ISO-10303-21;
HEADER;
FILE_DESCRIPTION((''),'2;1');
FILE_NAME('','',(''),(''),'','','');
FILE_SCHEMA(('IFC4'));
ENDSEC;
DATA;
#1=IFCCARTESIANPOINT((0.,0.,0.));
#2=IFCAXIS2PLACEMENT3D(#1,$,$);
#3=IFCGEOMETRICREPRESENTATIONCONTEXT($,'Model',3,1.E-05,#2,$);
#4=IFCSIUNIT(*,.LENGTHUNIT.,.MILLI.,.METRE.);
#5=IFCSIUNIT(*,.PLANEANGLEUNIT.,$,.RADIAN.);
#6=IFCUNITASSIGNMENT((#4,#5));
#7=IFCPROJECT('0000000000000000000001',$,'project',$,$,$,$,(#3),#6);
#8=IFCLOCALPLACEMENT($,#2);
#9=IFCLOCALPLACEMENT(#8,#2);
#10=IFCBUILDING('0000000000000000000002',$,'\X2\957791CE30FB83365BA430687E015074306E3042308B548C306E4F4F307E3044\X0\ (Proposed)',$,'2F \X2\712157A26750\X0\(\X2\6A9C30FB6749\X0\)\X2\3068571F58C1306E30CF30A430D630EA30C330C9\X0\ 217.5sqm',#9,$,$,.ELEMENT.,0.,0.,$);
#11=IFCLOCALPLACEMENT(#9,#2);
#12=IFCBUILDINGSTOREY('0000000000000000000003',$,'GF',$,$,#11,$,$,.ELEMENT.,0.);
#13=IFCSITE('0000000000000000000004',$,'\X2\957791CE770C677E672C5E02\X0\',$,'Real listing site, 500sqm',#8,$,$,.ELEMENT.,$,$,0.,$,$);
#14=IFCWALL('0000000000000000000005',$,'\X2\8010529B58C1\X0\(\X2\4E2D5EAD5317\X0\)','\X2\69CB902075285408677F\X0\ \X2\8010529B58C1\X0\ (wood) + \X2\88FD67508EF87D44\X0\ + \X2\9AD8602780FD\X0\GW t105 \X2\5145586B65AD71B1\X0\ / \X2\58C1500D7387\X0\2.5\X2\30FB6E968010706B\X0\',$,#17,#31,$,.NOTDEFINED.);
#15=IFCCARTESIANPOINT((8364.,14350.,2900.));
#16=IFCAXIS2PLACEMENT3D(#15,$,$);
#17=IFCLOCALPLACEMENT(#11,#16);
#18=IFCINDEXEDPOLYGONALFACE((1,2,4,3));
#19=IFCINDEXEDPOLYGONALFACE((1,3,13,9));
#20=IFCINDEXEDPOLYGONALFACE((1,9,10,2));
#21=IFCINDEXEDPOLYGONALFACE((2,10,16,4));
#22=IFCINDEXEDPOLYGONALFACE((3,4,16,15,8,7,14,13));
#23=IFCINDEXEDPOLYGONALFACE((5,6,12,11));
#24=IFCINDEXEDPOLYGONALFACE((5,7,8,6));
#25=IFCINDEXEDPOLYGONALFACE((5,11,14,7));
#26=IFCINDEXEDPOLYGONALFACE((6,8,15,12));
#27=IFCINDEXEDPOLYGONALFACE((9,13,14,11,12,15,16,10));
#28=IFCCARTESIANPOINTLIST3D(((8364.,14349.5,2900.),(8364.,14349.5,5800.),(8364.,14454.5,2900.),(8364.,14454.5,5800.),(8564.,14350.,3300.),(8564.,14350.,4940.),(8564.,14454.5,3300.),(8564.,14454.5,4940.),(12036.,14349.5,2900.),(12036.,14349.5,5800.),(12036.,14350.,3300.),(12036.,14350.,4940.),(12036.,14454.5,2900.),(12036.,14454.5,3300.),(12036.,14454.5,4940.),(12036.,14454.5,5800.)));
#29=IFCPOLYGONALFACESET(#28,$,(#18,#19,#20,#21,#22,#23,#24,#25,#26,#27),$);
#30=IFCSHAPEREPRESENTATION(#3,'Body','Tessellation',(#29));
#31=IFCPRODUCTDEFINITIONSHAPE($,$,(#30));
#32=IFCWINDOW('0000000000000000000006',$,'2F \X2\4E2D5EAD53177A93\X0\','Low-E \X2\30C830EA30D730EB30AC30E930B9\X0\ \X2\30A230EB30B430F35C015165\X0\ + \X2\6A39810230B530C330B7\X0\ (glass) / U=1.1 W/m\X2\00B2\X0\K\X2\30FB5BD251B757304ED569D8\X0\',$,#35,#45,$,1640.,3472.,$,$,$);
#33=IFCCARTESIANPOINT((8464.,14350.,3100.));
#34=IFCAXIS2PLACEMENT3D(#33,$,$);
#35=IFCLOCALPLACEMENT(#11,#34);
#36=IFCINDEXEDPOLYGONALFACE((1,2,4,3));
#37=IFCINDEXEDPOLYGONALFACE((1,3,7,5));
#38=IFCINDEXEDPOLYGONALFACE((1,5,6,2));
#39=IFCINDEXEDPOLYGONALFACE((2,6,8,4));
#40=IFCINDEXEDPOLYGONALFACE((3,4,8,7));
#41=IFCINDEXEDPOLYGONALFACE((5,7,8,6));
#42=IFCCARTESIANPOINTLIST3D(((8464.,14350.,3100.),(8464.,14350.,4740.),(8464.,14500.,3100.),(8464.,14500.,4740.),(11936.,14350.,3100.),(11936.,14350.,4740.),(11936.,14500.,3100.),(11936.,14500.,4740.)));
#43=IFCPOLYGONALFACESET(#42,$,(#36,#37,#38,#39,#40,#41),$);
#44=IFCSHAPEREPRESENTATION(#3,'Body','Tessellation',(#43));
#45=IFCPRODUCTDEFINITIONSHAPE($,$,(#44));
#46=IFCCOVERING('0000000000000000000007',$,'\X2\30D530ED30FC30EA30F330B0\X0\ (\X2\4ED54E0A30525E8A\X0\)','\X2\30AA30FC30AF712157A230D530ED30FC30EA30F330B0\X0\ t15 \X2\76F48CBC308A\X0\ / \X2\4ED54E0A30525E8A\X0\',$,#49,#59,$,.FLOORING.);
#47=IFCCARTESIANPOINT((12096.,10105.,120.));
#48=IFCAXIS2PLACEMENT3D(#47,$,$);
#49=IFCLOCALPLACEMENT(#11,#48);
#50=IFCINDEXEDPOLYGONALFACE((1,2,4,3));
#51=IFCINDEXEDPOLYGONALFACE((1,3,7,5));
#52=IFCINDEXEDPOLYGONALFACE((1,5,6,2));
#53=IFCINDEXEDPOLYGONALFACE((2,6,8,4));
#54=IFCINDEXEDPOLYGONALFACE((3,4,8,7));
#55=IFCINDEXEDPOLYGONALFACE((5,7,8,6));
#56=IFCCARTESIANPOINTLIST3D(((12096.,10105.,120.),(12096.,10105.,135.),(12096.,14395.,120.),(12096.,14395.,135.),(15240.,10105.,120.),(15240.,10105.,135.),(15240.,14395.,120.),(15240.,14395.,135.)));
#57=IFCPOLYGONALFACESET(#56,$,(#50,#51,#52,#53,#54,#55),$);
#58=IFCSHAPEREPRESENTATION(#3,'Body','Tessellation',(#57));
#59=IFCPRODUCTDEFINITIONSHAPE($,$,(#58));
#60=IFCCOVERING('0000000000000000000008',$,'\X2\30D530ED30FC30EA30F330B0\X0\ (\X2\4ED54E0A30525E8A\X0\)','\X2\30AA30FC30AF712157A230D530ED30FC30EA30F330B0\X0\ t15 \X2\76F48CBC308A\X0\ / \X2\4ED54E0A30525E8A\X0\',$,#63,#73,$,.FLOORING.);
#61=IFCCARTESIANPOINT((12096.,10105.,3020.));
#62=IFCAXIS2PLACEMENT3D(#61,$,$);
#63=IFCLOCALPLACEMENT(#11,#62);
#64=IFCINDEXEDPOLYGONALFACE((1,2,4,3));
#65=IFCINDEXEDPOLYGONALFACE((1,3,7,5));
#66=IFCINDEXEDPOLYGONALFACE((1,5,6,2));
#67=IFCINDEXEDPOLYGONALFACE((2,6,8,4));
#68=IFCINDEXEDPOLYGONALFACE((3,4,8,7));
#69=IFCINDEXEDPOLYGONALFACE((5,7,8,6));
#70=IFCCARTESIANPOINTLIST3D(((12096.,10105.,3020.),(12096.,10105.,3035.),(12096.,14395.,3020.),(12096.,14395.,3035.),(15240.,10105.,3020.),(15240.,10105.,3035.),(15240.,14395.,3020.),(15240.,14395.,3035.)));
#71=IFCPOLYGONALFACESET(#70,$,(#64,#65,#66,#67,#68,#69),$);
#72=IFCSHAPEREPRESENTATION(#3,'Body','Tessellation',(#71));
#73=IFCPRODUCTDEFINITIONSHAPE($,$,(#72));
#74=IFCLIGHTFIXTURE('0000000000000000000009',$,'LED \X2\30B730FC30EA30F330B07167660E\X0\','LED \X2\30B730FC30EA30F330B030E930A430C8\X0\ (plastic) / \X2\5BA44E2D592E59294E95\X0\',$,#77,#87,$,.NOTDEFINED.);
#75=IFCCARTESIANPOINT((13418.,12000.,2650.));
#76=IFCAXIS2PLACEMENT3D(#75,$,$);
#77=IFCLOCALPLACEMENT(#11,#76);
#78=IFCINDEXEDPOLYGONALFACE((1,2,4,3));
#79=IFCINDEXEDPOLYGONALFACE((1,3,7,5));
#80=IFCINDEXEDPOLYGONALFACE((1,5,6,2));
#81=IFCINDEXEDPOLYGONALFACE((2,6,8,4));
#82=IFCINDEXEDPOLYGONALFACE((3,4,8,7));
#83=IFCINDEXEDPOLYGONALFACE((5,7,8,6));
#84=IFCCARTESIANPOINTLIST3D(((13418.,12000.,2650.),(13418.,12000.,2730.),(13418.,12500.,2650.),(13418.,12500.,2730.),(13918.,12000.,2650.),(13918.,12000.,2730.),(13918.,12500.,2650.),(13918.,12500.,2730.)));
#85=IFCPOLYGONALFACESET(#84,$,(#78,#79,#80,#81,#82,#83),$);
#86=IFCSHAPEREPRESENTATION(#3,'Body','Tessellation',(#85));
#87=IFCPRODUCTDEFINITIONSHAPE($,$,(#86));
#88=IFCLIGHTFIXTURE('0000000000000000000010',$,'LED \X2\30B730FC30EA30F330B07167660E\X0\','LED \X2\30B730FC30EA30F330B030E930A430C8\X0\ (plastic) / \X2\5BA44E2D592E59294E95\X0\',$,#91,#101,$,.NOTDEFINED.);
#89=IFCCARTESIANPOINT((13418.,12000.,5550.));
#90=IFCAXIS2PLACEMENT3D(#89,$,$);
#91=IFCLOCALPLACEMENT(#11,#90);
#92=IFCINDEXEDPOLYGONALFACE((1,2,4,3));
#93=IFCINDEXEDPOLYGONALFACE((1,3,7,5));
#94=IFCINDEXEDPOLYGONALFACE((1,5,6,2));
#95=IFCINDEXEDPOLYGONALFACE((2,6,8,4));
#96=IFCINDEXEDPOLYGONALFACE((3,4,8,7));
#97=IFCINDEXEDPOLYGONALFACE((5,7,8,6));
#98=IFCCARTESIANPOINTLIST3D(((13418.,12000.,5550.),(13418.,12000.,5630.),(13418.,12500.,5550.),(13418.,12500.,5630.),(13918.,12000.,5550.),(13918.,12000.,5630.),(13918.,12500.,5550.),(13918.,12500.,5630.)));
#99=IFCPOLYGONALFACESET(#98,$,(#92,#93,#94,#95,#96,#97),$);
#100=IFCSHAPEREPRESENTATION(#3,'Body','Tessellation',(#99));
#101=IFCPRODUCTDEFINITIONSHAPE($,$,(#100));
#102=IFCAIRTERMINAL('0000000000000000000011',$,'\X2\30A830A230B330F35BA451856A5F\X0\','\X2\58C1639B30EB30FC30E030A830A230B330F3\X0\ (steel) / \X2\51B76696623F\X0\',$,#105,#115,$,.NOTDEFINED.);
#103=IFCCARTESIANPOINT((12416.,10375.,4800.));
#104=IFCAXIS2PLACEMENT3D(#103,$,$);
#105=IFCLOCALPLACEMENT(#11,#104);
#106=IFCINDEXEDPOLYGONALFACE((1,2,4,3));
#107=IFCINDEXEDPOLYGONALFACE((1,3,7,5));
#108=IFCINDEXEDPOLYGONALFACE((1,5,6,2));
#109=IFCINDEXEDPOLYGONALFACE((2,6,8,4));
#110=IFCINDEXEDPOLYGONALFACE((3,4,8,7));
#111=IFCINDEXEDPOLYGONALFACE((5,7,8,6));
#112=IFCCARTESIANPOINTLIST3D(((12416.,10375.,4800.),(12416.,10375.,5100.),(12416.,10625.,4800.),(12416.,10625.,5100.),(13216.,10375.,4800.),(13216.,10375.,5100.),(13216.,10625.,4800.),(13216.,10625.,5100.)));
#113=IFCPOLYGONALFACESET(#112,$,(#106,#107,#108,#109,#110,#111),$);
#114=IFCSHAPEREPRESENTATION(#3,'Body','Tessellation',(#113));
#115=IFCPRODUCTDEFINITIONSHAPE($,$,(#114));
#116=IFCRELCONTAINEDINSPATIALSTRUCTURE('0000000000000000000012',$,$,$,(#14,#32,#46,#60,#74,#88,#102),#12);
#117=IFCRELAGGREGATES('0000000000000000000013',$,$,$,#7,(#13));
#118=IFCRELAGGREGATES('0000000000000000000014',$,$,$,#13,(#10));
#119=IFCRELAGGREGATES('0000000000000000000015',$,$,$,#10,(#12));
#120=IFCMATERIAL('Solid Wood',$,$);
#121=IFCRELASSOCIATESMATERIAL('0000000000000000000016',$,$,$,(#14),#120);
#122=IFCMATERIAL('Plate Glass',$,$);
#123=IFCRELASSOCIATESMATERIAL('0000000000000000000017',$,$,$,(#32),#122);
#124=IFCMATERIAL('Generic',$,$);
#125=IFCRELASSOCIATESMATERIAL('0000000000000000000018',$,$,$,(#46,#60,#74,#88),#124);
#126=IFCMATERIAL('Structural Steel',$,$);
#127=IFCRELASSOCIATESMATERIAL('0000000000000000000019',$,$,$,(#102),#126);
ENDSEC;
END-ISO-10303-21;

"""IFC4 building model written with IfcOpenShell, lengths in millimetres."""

from ifc_helpers import new_model, si_unit, frame, frame_2d, origin, place, context, project, spatial, rectangle, extrude, material, element, fill, save


model = new_model("IFC4")

# Units and contexts
model_context = context("Model", 3, precision=1e-05, world=origin())
ifc_project = project(units=[si_unit("LENGTHUNIT", "METRE", prefix="MILLI"), si_unit("PLANEANGLEUNIT", "RADIAN")], contexts=[model_context])

# Site, building, storey
site_placement = place(None, origin())
site = spatial("IfcSite", under=ifc_project, at=site_placement, Name="長野県松本市", ObjectType="Real listing site, 500sqm", CompositionType="ELEMENT", RefElevation=0.0)
building_placement = place(site_placement, origin())
building = spatial("IfcBuilding", under=site, at=building_placement, Name="長野・茶室と縁側のある和の住まい (Proposed)", ObjectType="2F 無垢材(檜・杉)と土壁のハイブリッド 217.5sqm", CompositionType="ELEMENT", ElevationOfRefHeight=0.0, ElevationOfTerrain=0.0)
storey_placement = place(building_placement, origin())
storey = spatial("IfcBuildingStorey", under=building, at=storey_placement, Name="GF", CompositionType="ELEMENT", Elevation=0.0)

# Shared definitions
ifc_material_1 = material(Name="Solid Wood")

# Wall, opening, window
ifc_material_2 = material(Name="Plate Glass")
wall_1_placement = place(storey_placement, frame((8364.0, 14350.0, 2900.0)))
wall_1 = element("IfcWall", 1, at=wall_1_placement, inside=storey, material=ifc_material_1, Name="耐力壁(中庭北)", Description="構造用合板 耐力壁 (wood) + 製材軸組 + 高性能GW t105 充填断熱 / 壁倍率2.5・準耐火", PredefinedType="NOTDEFINED", context=model_context, shape_type="SweptSolid", body=[
    extrude(rectangle(XDim=3672.0, YDim=105.0, at=frame_2d((1836.0, 52.0))), frame((8364.0, 14350.0, 2900.0)), (0.0, 0.0, 1.0), 2900.0),
])
opening_1_placement = place(storey_placement, frame((8464.0, 14350.0, 3100.0)))
opening_1 = element("IfcOpeningElement", 2, at=opening_1_placement, cuts=wall_1, PredefinedType="NOTDEFINED", context=model_context, shape_type="SweptSolid", body=[
    extrude(rectangle(XDim=3472.0, YDim=150.0, at=frame_2d((1736.0, 75.0))), frame((8464.0, 14350.0, 3100.0)), (0.0, 0.0, 1.0), 1640.0),
])
window_1_placement = place(storey_placement, frame((8464.0, 14350.0, 3100.0)))
window_1 = element("IfcWindow", 3, at=window_1_placement, inside=storey, material=ifc_material_2, Name="2F 中庭北窓", Description="Low-E トリプルガラス アルゴン封入 + 樹脂サッシ (glass) / U=1.1 W/m²K・寒冷地仕様", OverallHeight=1640.0, OverallWidth=3472.0, context=model_context, shape_type="SweptSolid", body=[
    extrude(rectangle(XDim=3472.0, YDim=150.0, at=frame_2d((1736.0, 75.0))), frame((8464.0, 14350.0, 3100.0)), (0.0, 0.0, 1.0), 1640.0),
])
fill(opening_1, window_1)

# Coverings
ifc_material_3 = material(Name="Generic")
covering_1_placement = place(storey_placement, frame((12096.0, 10105.0, 120.0)))
element("IfcCovering", 4, at=covering_1_placement, inside=storey, material=ifc_material_3, Name="フローリング (仕上げ床)", Description="オーク無垢フローリング t15 直貼り / 仕上げ床", PredefinedType="FLOORING", context=model_context, shape_type="SweptSolid", body=[
    extrude(rectangle(XDim=3144.0, YDim=4290.0, at=frame_2d((1572.0, 2145.0))), frame((12096.0, 10105.0, 120.0)), (0.0, 0.0, 1.0), 15.0),
])
covering_2_placement = place(storey_placement, frame((12096.0, 10105.0, 3020.0)))
element("IfcCovering", 5, at=covering_2_placement, inside=storey, material=ifc_material_3, Name="フローリング (仕上げ床)", Description="オーク無垢フローリング t15 直貼り / 仕上げ床", PredefinedType="FLOORING", context=model_context, shape_type="SweptSolid", body=[
    extrude(rectangle(XDim=3144.0, YDim=4290.0, at=frame_2d((1572.0, 2145.0))), frame((12096.0, 10105.0, 3020.0)), (0.0, 0.0, 1.0), 15.0),
])

# Light fixtures
light_fixture_1_placement = place(storey_placement, frame((13418.0, 12000.0, 2650.0)))
element("IfcLightFixture", 6, at=light_fixture_1_placement, inside=storey, material=ifc_material_3, Name="LED シーリング照明", Description="LED シーリングライト (plastic) / 室中央天井", PredefinedType="NOTDEFINED", context=model_context, shape_type="SweptSolid", body=[
    extrude(rectangle(XDim=500.0, YDim=500.0, at=frame_2d((250.0, 250.0))), frame((13418.0, 12000.0, 2650.0)), (0.0, 0.0, 1.0), 80.0),
])
light_fixture_2_placement = place(storey_placement, frame((13418.0, 12000.0, 5550.0)))
element("IfcLightFixture", 7, at=light_fixture_2_placement, inside=storey, material=ifc_material_3, Name="LED シーリング照明", Description="LED シーリングライト (plastic) / 室中央天井", PredefinedType="NOTDEFINED", context=model_context, shape_type="SweptSolid", body=[
    extrude(rectangle(XDim=500.0, YDim=500.0, at=frame_2d((250.0, 250.0))), frame((13418.0, 12000.0, 5550.0)), (0.0, 0.0, 1.0), 80.0),
])

# Air terminal
ifc_material_4 = material(Name="Structural Steel")
air_terminal_placement = place(storey_placement, frame((12416.0, 10375.0, 4800.0)))
element("IfcAirTerminal", 8, at=air_terminal_placement, inside=storey, material=ifc_material_4, Name="エアコン室内機", Description="壁掛ルームエアコン (steel) / 冷暖房", PredefinedType="NOTDEFINED", context=model_context, shape_type="SweptSolid", body=[
    extrude(rectangle(XDim=800.0, YDim=250.0, at=frame_2d((400.0, 125.0))), frame((12416.0, 10375.0, 4800.0)), (0.0, 0.0, 1.0), 300.0),
])

save(model, "model.ifc")
